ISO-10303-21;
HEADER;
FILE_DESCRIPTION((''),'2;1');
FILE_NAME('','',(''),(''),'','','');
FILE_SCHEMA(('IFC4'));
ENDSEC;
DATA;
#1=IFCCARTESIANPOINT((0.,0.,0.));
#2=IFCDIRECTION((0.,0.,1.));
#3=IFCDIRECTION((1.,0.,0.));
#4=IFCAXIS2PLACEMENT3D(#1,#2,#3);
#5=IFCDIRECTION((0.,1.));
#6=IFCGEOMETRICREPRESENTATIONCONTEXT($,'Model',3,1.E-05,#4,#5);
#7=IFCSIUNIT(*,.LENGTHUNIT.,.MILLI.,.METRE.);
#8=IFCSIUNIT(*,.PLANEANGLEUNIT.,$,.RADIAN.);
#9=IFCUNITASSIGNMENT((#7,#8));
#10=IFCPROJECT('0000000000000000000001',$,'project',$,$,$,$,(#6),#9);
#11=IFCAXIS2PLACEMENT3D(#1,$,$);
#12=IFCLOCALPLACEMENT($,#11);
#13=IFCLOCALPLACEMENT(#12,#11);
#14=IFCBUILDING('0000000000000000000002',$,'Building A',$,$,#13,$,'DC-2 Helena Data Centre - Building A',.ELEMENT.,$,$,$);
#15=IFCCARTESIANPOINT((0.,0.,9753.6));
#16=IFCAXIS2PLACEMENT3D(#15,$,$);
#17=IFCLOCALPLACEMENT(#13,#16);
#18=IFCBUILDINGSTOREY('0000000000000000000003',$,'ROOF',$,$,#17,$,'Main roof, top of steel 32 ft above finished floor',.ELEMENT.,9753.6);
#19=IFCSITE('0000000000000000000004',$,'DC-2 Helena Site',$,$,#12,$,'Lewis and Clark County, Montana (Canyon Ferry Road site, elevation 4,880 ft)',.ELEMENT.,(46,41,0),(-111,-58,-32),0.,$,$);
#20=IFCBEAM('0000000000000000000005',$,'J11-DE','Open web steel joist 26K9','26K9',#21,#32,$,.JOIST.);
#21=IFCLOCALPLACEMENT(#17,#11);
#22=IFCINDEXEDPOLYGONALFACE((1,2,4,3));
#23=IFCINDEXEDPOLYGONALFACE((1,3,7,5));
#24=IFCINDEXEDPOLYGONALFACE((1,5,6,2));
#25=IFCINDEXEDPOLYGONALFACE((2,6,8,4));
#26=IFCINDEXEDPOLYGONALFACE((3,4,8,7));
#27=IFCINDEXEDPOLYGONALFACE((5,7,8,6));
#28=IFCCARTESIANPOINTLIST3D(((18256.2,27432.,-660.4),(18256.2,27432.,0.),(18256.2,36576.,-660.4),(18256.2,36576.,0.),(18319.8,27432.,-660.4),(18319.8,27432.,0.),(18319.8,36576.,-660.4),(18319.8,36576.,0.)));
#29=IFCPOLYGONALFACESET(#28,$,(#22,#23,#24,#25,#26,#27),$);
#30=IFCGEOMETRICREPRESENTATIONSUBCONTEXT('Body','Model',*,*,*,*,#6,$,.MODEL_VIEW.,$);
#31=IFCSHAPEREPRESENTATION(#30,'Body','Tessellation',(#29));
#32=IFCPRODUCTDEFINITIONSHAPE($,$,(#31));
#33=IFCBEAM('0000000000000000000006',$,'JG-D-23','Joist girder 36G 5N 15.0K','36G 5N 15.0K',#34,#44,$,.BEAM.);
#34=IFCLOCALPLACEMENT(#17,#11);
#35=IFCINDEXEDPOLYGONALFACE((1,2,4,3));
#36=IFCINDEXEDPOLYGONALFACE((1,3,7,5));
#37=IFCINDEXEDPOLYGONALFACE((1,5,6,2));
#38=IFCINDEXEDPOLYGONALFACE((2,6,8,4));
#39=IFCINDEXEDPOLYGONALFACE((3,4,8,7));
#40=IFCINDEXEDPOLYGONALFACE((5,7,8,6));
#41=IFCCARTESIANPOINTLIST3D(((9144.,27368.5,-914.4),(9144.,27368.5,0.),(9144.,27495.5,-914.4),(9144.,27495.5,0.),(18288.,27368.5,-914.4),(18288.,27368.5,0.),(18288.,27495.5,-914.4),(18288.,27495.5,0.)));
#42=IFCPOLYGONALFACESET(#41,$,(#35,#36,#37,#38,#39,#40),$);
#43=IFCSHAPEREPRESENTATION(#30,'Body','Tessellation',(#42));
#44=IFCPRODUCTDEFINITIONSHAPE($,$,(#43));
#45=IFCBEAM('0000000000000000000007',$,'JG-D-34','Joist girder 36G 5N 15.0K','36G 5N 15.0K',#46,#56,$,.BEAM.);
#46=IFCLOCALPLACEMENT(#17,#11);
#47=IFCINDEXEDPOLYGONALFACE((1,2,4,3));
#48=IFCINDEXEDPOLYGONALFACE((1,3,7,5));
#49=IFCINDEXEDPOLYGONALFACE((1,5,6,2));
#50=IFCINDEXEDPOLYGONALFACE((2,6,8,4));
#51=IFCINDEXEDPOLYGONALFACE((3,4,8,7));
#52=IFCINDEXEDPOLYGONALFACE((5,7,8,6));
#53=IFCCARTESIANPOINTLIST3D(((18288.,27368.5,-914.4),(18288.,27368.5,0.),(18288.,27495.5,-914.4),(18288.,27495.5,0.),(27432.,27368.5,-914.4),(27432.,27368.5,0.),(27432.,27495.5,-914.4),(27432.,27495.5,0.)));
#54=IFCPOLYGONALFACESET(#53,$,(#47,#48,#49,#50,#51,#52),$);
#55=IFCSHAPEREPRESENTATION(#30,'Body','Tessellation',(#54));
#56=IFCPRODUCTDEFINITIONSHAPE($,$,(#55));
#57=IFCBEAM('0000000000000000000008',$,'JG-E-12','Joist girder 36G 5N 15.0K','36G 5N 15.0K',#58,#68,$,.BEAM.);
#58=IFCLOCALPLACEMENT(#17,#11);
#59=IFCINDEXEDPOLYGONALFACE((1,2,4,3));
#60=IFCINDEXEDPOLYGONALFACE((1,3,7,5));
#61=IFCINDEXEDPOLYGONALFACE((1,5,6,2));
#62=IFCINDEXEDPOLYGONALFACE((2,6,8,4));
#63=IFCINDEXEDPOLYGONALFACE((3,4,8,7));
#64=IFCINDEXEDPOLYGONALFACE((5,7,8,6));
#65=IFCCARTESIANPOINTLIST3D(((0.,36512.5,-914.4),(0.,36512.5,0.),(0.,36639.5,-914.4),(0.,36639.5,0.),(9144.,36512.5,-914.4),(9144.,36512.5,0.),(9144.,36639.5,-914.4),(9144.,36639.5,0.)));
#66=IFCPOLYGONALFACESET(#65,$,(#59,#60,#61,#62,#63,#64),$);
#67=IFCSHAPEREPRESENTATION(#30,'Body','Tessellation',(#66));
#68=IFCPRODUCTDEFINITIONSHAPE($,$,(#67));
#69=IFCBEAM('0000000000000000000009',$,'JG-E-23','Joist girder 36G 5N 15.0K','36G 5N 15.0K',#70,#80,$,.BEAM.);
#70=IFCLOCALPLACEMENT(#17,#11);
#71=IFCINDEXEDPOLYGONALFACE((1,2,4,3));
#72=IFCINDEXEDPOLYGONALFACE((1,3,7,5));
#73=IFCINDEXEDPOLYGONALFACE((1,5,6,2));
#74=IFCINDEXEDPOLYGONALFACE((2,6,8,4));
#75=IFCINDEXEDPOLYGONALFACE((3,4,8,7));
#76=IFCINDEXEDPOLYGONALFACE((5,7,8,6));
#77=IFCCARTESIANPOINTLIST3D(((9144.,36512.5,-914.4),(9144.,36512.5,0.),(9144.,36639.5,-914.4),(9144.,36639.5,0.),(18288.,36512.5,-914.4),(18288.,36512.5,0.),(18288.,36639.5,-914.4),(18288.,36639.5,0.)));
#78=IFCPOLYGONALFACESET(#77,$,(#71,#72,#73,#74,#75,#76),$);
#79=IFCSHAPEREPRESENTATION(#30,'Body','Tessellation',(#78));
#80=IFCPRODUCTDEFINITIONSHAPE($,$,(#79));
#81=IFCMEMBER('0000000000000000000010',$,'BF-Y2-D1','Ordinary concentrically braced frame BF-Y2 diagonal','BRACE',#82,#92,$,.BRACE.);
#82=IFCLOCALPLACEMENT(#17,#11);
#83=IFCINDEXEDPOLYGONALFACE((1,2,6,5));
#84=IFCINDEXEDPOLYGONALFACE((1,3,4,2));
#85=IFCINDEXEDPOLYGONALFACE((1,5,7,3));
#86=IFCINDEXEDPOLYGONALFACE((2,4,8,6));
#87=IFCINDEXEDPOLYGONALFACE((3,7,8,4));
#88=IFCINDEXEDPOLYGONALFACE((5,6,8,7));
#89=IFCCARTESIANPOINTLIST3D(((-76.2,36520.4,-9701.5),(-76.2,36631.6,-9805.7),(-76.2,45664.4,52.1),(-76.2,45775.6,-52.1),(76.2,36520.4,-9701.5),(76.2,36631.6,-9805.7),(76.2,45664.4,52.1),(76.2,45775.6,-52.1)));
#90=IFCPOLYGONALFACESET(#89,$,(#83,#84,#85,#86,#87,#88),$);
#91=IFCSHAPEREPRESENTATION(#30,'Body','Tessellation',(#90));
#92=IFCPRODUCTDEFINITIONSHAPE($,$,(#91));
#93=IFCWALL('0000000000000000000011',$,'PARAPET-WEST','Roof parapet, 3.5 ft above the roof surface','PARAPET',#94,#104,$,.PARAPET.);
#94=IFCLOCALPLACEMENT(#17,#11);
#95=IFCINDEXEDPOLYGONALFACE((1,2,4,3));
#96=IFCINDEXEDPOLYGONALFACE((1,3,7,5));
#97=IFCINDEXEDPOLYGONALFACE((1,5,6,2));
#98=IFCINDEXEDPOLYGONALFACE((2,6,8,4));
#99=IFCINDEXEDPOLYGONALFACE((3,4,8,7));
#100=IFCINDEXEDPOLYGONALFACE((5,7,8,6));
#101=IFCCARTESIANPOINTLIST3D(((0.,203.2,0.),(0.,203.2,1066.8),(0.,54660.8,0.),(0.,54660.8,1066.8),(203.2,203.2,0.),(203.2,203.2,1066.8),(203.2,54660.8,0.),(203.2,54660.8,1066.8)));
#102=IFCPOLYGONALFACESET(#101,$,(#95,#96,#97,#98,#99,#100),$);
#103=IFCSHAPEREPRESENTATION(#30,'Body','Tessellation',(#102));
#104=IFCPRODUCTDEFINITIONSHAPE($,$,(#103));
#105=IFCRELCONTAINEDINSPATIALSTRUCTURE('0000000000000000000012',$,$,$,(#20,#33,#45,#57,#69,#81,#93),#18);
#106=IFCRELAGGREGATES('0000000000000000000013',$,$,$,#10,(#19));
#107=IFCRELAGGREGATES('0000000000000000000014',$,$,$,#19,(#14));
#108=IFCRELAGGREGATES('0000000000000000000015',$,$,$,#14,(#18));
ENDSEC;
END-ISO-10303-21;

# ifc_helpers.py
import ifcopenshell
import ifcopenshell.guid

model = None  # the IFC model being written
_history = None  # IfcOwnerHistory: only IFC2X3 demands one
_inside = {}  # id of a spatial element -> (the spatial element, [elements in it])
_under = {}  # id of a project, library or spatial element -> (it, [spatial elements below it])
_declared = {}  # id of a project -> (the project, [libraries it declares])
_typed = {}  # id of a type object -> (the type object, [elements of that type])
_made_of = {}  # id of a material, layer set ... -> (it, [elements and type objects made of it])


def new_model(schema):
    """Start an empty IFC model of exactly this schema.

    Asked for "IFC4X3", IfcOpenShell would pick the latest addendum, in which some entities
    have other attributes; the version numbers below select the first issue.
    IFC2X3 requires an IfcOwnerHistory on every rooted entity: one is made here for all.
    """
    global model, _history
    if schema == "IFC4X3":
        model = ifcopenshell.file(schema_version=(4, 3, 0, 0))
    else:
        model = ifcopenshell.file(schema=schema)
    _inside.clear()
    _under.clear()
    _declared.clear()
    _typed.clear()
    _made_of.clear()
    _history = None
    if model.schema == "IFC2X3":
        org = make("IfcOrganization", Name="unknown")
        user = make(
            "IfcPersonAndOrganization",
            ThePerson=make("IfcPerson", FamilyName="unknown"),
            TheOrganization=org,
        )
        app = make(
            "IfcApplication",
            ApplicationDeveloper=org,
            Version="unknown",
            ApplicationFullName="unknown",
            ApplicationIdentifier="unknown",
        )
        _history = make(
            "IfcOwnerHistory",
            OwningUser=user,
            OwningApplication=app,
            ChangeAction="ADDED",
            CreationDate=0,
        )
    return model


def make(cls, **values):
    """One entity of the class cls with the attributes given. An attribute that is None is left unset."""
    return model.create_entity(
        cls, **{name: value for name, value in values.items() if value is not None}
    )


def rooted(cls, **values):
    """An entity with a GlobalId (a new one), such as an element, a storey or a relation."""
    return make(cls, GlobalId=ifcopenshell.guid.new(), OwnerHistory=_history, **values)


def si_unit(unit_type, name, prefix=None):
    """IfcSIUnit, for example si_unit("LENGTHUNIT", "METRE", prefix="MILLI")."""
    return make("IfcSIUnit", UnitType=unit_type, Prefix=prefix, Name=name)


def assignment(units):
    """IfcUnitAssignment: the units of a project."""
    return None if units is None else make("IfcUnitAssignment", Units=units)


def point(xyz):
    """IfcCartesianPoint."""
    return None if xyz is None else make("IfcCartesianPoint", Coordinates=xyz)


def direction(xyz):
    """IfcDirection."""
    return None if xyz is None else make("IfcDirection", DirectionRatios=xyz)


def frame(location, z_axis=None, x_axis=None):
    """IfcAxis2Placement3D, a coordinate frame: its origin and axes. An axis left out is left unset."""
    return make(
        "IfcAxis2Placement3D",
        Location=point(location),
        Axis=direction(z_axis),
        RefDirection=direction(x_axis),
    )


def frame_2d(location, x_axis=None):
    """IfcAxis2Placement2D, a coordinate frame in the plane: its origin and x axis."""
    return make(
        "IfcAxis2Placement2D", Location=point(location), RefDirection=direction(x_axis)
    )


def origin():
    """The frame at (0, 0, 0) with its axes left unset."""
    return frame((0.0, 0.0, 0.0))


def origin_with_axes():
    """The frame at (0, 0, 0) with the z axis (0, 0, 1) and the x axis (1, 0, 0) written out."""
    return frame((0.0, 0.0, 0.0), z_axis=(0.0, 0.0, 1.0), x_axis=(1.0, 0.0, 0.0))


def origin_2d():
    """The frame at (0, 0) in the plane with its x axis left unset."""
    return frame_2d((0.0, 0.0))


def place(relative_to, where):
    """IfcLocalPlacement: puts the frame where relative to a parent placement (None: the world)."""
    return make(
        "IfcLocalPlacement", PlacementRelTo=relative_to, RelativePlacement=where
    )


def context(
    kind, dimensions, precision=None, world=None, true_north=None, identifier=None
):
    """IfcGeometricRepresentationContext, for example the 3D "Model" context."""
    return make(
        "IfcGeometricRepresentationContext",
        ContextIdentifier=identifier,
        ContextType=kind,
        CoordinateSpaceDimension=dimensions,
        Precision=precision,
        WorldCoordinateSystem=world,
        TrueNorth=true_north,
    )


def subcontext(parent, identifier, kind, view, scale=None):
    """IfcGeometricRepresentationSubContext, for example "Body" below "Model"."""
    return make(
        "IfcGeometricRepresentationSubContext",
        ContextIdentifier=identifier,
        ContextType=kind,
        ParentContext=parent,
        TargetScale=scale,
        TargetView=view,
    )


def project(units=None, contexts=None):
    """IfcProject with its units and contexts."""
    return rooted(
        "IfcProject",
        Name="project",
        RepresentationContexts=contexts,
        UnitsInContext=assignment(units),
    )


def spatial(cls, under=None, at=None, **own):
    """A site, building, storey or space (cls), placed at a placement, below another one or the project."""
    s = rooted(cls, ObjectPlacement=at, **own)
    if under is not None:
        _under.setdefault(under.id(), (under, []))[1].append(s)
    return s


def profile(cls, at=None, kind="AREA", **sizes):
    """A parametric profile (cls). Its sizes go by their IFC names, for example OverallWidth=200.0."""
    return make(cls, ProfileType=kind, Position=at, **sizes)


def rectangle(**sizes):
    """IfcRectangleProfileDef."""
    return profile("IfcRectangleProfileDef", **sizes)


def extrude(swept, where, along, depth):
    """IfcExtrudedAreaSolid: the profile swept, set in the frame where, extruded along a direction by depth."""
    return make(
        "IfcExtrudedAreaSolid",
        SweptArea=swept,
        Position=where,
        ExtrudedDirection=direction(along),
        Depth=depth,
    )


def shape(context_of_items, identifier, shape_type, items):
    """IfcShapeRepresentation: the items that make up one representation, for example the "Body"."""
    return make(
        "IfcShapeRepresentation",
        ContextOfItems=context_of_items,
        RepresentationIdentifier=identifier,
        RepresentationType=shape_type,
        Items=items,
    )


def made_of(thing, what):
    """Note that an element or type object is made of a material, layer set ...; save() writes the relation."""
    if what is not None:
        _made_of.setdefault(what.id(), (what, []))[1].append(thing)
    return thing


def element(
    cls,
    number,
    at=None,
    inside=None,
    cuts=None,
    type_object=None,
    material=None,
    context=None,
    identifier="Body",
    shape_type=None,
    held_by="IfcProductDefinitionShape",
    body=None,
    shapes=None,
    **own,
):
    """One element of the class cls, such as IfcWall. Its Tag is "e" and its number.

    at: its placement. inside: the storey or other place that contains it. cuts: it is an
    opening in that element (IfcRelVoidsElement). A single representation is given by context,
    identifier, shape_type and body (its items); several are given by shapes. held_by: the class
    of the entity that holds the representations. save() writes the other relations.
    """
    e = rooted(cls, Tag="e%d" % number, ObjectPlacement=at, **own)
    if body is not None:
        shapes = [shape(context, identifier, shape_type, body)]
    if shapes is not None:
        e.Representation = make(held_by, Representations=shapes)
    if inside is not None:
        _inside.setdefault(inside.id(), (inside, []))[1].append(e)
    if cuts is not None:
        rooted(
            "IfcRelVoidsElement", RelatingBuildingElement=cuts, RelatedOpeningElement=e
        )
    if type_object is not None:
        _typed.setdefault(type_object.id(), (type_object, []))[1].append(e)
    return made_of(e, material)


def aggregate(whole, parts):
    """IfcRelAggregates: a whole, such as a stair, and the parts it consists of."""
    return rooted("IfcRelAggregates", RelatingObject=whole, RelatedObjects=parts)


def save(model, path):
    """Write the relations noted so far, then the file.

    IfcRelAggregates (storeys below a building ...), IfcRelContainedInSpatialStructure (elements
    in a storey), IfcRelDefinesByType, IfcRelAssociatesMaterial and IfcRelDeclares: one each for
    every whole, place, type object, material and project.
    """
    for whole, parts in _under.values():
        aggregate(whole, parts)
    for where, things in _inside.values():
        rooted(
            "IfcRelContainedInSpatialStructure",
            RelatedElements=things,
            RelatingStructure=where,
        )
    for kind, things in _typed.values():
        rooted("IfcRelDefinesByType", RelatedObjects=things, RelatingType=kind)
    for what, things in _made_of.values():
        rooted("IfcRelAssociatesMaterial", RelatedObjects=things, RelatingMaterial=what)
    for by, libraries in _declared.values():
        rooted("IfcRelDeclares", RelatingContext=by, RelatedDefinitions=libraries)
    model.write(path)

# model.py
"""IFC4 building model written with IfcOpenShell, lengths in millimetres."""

from ifc_helpers import new_model, si_unit, direction, frame, origin, origin_with_axes, origin_2d, place, context, subcontext, project, spatial, rectangle, extrude, element, save


model = new_model("IFC4")

# Units and contexts
model_context = context("Model", 3, precision=1e-05, world=origin_with_axes(), true_north=direction((0.0, 1.0)))
body_context = subcontext(model_context, "Body", "Model", "MODEL_VIEW")
ifc_project = project(units=[si_unit("LENGTHUNIT", "METRE", prefix="MILLI"), si_unit("PLANEANGLEUNIT", "RADIAN")], contexts=[model_context])

# Site, building, storey
site_placement = place(None, origin())
site = spatial("IfcSite", under=ifc_project, at=site_placement, Name="DC-2 Helena Site", LongName="Lewis and Clark County, Montana (Canyon Ferry Road site, elevation 4,880 ft)", CompositionType="ELEMENT", RefLatitude=(46, 41, 0), RefLongitude=(-111, -58, -32), RefElevation=0.0)
building_placement = place(site_placement, origin())
building = spatial("IfcBuilding", under=site, at=building_placement, Name="Building A", LongName="DC-2 Helena Data Centre - Building A", CompositionType="ELEMENT")
storey_placement = place(building_placement, frame((0.0, 0.0, 9753.6)))
storey = spatial("IfcBuildingStorey", under=building, at=storey_placement, Name="ROOF", LongName="Main roof, top of steel 32 ft above finished floor", CompositionType="ELEMENT", Elevation=9753.6)

# Shared definitions
placement_1 = place(storey_placement, frame((0.0, 36576.0, -9753.6)))

# Beams
placement_2 = place(storey_placement, frame((0.0, 36576.0, 0.0)))
placement_3 = place(storey_placement, frame((9144.0, 27432.0, 0.0)))
placement_4 = place(storey_placement, frame((9144.0, 36576.0, 0.0)))
placement_5 = place(storey_placement, frame((18288.0, 27432.0, 0.0)))
element("IfcBeam", 1, at=placement_5, inside=storey, Name="J11-DE", Description="Open web steel joist 26K9", ObjectType="26K9", PredefinedType="JOIST", context=body_context, shape_type="SweptSolid", body=[
    extrude(rectangle(XDim=63.5, YDim=660.4, at=origin_2d()), frame((0.0, 0.0, -330.2), z_axis=(0.0, 1.0, 0.0), x_axis=(1.0, 0.0, 0.0)), (0.0, 0.0, 1.0), 9144.0),
])
element("IfcBeam", 2, at=placement_3, inside=storey, Name="JG-D-23", Description="Joist girder 36G 5N 15.0K", ObjectType="36G 5N 15.0K", PredefinedType="BEAM", context=body_context, shape_type="SweptSolid", body=[
    extrude(rectangle(XDim=127.0, YDim=914.4, at=origin_2d()), frame((0.0, 0.0, -457.2), z_axis=(1.0, 0.0, 0.0), x_axis=(0.0, 1.0, 0.0)), (0.0, 0.0, 1.0), 9144.0),
])
element("IfcBeam", 3, at=placement_5, inside=storey, Name="JG-D-34", Description="Joist girder 36G 5N 15.0K", ObjectType="36G 5N 15.0K", PredefinedType="BEAM", context=body_context, shape_type="SweptSolid", body=[
    extrude(rectangle(XDim=127.0, YDim=914.4, at=origin_2d()), frame((0.0, 0.0, -457.2), z_axis=(1.0, 0.0, 0.0), x_axis=(0.0, 1.0, 0.0)), (0.0, 0.0, 1.0), 9144.0),
])
element("IfcBeam", 4, at=placement_2, inside=storey, Name="JG-E-12", Description="Joist girder 36G 5N 15.0K", ObjectType="36G 5N 15.0K", PredefinedType="BEAM", context=body_context, shape_type="SweptSolid", body=[
    extrude(rectangle(XDim=127.0, YDim=914.4, at=origin_2d()), frame((0.0, 0.0, -457.2), z_axis=(1.0, 0.0, 0.0), x_axis=(0.0, 1.0, 0.0)), (0.0, 0.0, 1.0), 9144.0),
])
element("IfcBeam", 5, at=placement_4, inside=storey, Name="JG-E-23", Description="Joist girder 36G 5N 15.0K", ObjectType="36G 5N 15.0K", PredefinedType="BEAM", context=body_context, shape_type="SweptSolid", body=[
    extrude(rectangle(XDim=127.0, YDim=914.4, at=origin_2d()), frame((0.0, 0.0, -457.2), z_axis=(1.0, 0.0, 0.0), x_axis=(0.0, 1.0, 0.0)), (0.0, 0.0, 1.0), 9144.0),
])

# Member
element("IfcMember", 6, at=placement_1, inside=storey, Name="BF-Y2-D1", Description="Ordinary concentrically braced frame BF-Y2 diagonal", ObjectType="BRACE", PredefinedType="BRACE", context=body_context, shape_type="SweptSolid", body=[
    extrude(rectangle(XDim=152.4, YDim=152.4, at=origin_2d()), frame((0.0, 0.0, 0.0), z_axis=(0.0, 0.683941, 0.729537), x_axis=(1.0, 0.0, 0.0)), (0.0, 0.0, 1.0), 13369.6),
])

# Wall
wall_placement = place(storey_placement, frame((101.6, 27432.0, 0.0)))
element("IfcWall", 7, at=wall_placement, inside=storey, Name="PARAPET-WEST", Description="Roof parapet, 3.5 ft above the roof surface", ObjectType="PARAPET", PredefinedType="PARAPET", context=body_context, shape_type="SweptSolid", body=[
    extrude(rectangle(XDim=203.2, YDim=54457.6, at=origin_2d()), origin(), (0.0, 0.0, 1.0), 1066.8),
])

save(model, "model.ifc")
